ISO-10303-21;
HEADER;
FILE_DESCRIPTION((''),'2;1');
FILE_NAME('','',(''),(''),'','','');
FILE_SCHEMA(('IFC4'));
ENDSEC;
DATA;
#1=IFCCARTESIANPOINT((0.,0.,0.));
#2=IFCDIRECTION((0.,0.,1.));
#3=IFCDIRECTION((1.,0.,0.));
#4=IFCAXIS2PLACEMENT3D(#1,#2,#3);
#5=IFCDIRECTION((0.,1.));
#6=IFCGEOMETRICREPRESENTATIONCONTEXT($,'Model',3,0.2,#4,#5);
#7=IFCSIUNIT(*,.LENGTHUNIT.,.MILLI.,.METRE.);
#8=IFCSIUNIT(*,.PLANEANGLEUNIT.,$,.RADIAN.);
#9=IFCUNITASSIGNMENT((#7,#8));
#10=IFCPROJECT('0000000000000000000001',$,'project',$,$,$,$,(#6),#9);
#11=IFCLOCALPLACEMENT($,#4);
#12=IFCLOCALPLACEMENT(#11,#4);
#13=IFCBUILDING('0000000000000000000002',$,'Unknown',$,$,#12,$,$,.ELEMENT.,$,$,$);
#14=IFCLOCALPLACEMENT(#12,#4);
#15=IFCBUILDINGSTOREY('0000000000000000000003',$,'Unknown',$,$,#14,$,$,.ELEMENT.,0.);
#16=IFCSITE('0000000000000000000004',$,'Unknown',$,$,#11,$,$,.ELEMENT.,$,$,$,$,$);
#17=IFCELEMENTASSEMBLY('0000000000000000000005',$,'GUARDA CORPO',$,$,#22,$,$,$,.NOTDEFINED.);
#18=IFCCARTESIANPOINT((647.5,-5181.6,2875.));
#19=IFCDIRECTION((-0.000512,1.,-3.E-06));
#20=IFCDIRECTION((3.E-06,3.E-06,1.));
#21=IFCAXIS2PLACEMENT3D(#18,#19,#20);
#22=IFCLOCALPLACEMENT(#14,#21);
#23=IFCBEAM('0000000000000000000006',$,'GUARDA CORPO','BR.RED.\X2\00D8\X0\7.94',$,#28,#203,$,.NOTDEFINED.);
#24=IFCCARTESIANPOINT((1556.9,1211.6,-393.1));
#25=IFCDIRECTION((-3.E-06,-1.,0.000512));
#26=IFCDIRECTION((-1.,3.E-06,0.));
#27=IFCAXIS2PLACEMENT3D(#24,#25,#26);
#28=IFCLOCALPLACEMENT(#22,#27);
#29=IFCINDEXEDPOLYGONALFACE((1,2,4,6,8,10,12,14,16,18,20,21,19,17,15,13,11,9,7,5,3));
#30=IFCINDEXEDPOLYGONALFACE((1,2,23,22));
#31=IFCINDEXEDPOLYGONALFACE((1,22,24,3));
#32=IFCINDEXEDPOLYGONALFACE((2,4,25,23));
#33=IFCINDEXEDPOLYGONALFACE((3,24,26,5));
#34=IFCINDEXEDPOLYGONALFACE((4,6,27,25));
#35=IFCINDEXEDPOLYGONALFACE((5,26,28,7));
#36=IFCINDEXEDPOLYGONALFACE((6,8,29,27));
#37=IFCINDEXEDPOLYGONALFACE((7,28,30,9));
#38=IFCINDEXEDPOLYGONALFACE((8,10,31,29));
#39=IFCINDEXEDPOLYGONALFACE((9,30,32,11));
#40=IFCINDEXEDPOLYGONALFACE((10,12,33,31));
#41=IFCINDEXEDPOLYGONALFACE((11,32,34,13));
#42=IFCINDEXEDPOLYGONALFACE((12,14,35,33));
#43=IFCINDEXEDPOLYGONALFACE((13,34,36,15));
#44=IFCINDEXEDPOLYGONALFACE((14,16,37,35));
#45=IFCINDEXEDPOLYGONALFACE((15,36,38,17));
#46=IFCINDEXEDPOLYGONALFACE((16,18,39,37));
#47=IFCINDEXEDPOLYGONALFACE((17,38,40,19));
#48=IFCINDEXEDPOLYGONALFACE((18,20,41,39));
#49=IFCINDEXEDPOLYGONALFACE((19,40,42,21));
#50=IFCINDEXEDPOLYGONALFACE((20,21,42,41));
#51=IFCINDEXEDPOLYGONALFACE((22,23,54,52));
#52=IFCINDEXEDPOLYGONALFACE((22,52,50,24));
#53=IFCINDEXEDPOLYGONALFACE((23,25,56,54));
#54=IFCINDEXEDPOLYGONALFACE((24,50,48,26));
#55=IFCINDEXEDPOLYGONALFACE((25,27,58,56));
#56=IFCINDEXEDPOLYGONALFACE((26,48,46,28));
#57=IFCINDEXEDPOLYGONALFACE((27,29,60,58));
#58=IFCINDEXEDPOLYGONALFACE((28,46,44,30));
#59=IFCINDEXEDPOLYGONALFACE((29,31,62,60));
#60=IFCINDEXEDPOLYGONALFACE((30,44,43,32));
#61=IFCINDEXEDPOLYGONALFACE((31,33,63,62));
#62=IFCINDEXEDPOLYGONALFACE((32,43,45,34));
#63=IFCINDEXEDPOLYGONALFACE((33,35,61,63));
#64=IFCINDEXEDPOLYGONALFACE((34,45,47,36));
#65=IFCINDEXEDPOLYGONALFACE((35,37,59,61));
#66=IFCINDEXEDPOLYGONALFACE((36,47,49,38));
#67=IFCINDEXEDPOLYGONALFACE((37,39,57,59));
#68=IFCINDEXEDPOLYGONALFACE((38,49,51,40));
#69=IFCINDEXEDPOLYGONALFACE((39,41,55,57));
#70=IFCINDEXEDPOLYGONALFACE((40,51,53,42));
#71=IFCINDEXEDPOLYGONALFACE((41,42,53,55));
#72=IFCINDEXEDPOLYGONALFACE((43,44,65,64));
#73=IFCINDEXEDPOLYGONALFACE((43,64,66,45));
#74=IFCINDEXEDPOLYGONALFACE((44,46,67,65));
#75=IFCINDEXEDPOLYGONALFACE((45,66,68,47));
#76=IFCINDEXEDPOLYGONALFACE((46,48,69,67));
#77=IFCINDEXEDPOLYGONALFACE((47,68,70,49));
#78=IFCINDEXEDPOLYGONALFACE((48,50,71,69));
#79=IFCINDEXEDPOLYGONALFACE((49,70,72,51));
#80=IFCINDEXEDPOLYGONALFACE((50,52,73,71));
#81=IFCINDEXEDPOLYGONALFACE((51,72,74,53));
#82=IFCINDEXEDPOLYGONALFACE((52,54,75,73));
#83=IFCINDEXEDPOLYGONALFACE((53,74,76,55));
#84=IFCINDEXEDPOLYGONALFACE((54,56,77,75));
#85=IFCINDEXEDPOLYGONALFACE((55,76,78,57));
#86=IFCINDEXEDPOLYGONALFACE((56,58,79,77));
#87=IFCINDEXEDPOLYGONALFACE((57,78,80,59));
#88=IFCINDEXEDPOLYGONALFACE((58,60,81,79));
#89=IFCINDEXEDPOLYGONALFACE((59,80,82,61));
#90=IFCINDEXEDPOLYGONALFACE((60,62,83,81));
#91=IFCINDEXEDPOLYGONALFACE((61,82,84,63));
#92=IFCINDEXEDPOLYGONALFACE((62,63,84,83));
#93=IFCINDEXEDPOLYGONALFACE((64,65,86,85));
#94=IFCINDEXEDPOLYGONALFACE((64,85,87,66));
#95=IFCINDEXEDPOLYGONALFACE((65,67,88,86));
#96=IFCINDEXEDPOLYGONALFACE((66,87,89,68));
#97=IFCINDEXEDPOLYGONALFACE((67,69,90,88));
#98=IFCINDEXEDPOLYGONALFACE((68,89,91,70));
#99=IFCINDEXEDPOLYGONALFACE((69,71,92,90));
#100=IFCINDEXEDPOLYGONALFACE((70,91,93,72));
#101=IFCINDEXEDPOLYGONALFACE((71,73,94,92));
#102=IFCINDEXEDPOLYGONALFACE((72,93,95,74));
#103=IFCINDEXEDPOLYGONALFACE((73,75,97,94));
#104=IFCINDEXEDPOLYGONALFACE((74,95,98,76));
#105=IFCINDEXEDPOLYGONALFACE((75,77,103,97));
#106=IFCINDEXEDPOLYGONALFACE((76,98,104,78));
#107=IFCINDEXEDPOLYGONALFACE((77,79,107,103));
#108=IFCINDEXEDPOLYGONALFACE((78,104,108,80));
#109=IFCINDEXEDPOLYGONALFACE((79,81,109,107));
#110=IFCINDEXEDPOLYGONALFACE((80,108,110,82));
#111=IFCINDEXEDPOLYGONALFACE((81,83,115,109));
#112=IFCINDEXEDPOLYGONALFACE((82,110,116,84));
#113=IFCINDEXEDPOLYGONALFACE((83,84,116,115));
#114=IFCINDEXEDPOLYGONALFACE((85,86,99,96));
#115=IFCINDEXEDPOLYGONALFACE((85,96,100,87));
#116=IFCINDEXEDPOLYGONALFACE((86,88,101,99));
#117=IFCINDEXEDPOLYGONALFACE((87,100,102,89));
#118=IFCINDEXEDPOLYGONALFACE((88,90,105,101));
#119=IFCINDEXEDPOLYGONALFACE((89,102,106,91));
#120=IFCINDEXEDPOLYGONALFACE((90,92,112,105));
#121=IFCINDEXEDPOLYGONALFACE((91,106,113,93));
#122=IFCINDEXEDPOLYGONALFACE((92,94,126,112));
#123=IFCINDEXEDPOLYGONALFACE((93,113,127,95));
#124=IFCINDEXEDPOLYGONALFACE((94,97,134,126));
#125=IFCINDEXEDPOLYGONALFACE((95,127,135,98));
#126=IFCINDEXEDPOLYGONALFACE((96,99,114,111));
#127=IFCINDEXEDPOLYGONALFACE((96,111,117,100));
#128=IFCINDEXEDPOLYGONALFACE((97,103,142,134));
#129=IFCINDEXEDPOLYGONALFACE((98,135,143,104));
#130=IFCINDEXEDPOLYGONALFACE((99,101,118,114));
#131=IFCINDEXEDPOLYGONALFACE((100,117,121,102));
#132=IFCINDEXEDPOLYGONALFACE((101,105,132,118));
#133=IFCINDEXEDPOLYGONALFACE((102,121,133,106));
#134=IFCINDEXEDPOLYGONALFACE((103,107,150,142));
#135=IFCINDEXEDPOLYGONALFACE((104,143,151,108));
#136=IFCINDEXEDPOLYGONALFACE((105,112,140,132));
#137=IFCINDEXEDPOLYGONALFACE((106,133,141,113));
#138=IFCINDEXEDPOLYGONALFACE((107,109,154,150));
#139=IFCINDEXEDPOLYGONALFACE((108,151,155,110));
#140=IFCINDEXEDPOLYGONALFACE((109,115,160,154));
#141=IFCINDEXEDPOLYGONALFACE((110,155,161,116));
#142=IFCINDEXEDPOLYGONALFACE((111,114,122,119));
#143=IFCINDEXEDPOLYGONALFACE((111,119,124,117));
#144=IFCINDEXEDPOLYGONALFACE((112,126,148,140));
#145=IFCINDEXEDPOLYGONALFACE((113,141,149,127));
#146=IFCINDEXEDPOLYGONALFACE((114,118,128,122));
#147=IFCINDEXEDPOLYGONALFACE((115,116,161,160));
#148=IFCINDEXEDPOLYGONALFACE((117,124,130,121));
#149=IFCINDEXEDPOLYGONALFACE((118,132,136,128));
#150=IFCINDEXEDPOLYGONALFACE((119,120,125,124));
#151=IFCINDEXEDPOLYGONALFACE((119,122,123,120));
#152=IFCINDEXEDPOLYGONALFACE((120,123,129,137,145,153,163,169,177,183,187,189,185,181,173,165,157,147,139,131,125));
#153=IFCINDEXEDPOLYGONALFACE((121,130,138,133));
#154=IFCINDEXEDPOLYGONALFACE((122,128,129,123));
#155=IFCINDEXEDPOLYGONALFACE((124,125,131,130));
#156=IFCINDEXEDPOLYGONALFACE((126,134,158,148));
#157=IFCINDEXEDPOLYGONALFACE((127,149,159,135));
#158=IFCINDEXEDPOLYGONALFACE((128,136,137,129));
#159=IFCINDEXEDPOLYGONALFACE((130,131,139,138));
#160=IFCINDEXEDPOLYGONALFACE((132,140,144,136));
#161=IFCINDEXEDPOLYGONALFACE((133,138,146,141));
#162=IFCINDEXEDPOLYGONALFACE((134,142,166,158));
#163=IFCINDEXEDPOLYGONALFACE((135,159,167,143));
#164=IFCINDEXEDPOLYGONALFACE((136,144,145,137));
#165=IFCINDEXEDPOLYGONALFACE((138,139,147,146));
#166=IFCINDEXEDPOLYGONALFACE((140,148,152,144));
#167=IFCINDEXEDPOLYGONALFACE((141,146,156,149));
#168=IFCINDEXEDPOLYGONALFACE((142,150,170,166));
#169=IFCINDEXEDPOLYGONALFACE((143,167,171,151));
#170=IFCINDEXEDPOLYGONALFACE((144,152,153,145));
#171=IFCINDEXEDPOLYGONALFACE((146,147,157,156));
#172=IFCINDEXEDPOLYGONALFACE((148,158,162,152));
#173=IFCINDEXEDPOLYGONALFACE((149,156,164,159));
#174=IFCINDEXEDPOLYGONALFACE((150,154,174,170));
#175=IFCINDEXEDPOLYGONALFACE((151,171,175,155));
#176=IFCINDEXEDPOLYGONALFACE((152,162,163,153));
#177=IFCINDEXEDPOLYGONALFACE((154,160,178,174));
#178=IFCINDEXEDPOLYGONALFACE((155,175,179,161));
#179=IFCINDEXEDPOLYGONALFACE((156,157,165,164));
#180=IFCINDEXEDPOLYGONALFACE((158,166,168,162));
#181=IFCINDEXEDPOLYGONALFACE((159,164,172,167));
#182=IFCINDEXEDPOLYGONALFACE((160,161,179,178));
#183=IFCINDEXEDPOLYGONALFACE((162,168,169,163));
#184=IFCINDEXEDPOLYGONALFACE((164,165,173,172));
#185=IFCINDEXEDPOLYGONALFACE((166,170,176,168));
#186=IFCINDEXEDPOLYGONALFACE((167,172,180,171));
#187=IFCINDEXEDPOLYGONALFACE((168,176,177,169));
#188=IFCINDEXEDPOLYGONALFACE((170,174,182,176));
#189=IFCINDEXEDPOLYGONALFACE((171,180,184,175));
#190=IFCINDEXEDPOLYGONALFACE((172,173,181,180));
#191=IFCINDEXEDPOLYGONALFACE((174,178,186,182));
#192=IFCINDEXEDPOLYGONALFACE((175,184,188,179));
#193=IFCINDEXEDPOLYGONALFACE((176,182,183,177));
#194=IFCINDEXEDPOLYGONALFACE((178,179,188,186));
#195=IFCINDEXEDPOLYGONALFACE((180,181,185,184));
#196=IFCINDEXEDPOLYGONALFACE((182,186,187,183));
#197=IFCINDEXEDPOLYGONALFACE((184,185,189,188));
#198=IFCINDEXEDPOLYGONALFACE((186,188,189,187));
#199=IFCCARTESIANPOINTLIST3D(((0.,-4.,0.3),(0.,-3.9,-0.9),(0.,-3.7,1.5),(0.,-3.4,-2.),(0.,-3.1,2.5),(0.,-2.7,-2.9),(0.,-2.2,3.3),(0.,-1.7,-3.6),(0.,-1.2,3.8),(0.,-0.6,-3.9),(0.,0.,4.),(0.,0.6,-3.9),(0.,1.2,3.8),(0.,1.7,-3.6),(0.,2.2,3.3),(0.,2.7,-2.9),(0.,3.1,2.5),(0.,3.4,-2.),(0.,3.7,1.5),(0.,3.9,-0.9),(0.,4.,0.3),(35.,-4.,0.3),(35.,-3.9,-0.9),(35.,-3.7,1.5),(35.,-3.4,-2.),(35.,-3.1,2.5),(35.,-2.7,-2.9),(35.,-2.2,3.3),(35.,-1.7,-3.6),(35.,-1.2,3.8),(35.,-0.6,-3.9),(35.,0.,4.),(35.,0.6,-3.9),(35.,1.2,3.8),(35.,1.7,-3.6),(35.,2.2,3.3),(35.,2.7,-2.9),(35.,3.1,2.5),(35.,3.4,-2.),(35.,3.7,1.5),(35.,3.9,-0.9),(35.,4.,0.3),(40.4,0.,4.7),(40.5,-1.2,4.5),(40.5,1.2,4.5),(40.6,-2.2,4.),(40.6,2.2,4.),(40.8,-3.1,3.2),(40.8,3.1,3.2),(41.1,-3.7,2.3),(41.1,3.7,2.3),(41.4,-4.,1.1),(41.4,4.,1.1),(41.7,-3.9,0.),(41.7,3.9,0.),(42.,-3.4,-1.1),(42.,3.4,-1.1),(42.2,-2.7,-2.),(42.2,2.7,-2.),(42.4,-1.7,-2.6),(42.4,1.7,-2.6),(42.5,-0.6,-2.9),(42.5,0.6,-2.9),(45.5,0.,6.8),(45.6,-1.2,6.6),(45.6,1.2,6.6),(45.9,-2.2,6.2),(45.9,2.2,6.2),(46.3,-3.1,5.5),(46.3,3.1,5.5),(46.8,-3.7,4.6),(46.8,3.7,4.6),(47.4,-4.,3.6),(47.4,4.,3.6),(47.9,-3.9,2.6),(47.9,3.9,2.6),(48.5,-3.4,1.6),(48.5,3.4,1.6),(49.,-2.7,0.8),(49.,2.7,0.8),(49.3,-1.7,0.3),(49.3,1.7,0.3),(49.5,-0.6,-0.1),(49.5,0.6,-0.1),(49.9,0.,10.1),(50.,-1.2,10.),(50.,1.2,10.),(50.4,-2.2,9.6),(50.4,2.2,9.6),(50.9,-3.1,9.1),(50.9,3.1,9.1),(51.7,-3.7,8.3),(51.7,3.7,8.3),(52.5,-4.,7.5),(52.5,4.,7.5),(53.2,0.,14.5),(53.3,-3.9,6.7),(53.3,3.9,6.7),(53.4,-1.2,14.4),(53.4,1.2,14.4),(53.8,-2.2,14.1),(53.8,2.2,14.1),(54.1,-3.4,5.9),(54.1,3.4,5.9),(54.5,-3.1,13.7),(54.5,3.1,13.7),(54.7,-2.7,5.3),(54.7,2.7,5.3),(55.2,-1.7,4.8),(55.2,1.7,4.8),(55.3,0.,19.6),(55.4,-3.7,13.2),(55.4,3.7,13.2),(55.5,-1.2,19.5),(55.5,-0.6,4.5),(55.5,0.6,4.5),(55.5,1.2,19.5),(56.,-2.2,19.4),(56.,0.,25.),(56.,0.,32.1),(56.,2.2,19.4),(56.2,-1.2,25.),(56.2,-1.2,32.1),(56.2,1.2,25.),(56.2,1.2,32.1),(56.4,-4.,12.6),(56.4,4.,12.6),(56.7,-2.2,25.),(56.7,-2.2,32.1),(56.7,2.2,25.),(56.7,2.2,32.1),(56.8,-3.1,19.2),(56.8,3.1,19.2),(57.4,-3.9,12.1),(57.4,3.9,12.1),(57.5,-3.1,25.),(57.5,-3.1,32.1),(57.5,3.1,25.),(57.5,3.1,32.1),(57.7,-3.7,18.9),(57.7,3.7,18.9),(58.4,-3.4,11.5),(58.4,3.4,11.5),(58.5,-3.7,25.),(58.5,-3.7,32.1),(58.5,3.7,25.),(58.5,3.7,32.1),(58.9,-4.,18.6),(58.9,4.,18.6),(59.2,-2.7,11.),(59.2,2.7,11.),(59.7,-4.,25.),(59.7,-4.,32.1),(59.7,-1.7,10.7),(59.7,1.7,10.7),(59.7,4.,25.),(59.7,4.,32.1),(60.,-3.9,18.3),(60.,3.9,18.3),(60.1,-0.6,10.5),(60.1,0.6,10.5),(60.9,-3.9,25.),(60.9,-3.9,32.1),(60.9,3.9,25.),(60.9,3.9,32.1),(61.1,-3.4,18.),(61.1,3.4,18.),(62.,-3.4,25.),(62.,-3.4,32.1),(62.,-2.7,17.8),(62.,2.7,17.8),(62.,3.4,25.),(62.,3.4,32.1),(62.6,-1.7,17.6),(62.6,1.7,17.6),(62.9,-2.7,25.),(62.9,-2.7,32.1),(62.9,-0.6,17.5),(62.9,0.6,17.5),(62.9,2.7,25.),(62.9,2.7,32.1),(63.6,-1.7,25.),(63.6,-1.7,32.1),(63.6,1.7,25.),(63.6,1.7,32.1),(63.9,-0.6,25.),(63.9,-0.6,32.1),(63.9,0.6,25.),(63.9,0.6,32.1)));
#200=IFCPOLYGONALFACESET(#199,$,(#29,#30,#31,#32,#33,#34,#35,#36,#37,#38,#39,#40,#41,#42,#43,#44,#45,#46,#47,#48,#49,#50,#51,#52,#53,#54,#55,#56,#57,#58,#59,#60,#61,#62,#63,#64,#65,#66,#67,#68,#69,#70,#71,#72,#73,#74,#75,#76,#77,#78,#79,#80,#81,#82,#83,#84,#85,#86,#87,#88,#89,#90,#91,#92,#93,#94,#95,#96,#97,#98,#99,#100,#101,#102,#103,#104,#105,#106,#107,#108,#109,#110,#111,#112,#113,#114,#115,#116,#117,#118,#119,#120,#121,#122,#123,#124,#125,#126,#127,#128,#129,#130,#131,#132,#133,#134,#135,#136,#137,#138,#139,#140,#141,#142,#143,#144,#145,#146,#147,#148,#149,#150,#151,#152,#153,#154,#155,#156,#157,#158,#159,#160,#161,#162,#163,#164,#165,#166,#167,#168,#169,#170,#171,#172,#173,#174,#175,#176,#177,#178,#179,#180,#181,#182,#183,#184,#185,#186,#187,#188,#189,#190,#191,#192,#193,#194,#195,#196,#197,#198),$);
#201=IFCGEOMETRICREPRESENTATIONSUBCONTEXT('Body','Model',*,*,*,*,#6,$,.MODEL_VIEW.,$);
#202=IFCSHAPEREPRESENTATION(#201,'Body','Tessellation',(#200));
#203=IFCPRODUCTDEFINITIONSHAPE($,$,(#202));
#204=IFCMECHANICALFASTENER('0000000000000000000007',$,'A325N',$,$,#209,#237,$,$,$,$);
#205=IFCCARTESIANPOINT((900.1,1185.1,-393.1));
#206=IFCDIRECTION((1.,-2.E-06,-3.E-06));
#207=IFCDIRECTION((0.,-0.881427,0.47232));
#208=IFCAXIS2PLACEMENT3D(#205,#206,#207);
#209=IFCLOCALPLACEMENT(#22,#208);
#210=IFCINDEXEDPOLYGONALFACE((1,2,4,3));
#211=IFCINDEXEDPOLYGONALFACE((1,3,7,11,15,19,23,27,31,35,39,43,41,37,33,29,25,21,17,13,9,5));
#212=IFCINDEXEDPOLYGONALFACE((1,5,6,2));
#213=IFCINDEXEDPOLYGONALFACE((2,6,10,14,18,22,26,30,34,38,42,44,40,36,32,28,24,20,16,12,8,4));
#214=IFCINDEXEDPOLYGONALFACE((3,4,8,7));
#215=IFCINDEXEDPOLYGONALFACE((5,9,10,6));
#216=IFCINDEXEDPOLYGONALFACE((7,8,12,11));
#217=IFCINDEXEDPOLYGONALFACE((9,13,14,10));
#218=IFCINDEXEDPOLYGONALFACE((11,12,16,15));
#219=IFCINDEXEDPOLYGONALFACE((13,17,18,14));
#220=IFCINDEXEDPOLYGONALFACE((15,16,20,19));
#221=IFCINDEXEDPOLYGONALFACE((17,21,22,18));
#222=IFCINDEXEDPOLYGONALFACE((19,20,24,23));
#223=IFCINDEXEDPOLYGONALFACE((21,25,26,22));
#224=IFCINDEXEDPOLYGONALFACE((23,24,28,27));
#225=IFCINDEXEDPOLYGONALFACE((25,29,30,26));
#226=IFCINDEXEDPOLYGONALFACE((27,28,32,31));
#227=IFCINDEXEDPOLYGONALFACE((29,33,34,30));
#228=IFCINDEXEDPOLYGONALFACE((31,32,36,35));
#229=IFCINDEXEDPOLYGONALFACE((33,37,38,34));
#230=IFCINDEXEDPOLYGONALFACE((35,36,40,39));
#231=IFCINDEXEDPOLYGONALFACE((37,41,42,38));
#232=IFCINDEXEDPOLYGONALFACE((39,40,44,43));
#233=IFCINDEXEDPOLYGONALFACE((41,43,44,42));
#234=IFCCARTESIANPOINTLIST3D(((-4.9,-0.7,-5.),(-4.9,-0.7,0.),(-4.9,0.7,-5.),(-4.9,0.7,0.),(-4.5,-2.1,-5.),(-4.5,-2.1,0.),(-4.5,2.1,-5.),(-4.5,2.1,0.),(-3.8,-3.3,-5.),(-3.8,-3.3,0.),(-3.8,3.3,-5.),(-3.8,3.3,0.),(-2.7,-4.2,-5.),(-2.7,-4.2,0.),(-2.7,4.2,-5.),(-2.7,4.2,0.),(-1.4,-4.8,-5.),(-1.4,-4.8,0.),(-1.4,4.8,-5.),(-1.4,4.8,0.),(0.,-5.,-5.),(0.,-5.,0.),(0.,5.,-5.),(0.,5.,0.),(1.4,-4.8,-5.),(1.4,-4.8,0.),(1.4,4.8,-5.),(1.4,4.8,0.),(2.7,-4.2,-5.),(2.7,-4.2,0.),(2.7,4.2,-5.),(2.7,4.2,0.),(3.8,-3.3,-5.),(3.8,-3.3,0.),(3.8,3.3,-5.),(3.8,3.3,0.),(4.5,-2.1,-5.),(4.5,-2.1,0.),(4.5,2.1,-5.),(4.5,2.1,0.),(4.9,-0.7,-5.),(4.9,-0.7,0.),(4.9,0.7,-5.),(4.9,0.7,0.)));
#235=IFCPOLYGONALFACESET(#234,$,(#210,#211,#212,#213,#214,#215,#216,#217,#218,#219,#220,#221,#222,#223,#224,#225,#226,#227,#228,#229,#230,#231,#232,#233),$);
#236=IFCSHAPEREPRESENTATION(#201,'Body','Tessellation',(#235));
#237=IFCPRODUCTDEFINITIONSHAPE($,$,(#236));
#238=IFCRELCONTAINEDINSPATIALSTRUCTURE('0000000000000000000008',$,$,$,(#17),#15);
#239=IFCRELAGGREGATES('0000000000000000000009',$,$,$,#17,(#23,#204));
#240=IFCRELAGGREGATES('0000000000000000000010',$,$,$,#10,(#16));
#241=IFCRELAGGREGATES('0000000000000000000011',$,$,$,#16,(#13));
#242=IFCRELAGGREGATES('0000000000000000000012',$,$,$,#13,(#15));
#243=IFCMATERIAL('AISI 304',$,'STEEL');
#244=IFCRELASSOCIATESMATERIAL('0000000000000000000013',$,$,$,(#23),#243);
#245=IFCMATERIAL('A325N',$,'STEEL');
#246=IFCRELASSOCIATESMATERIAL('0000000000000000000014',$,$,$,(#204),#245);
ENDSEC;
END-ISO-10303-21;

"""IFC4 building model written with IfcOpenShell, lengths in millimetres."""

from ifc_helpers import new_model, entity, si_unit, direction, frame, origin_with_axes, place, context, subcontext, project, spatial, arc, indexed_curve, outline, extrude, source, transform, mapped, material, element, aggregate, save


model = new_model("IFC4")

# Units and contexts
model_context = context("Model", 3, precision=0.2, world=origin_with_axes(), true_north=direction((0.0, 1.0)))
body_context = subcontext(model_context, "Body", "Model", "MODEL_VIEW")
ifc_project = project(units=[si_unit("LENGTHUNIT", "METRE", prefix="MILLI"), si_unit("PLANEANGLEUNIT", "RADIAN")], contexts=[model_context])

# Site, building, storey
site_placement = place(None, origin_with_axes())
site = spatial("IfcSite", under=ifc_project, at=site_placement, Name="Unknown", CompositionType="ELEMENT")
building_placement = place(site_placement, origin_with_axes())
building = spatial("IfcBuilding", under=site, at=building_placement, Name="Unknown", CompositionType="ELEMENT")
storey_placement = place(building_placement, origin_with_axes())
storey = spatial("IfcBuildingStorey", under=building, at=storey_placement, Name="Unknown", CompositionType="ELEMENT", Elevation=0.0)

# Element assembly, beam
assembly_1_placement = place(storey_placement, frame((647.5, -5181.6, 2875.0), z_axis=(-0.000512, 1.0, -0.000003), x_axis=(0.000003, 0.000003, 1.0)))
assembly_1 = element("IfcElementAssembly", 1, at=assembly_1_placement, inside=storey, Name="GUARDA CORPO", PredefinedType="NOTDEFINED")
ifc_material_1 = material(Name="AISI 304", Category="STEEL")
beam_1_placement = place(assembly_1_placement, frame((1556.9, 1211.6, -393.1), z_axis=(-0.000003, -1.0, 0.000512), x_axis=(-1.0, 0.000003, 0.0)))
beam_1 = element("IfcBeam", 2, at=beam_1_placement, material=ifc_material_1, Name="GUARDA CORPO", Description="BR.RED.Ø7.94", PredefinedType="NOTDEFINED", context=body_context, shape_type="SolidModel", body=[
    entity("IfcSweptDiskSolid", entity("IfcIndexedPolyCurve", entity("IfcCartesianPointList3D", [[0.0, 0.0, 0.0], [35.0, 0.0, 0.0], [52.7, 0.0, 7.3], [60.0, 0.0, 25.0], [60.0, 0.0, 32.1]]), [entity("IfcLineIndex", [1, 2]), entity("IfcArcIndex", [2, 3, 4]), entity("IfcLineIndex", [4, 5])]), 4.0),
])

# Mechanical fastener
ifc_material_2 = material(Name="A325N", Category="STEEL")
shared_shape_1 = source(origin_with_axes(), body_context, "Body", "SweptSolid", [
    extrude(outline(indexed_curve([(5.0, 0.0), (0.0, 5.0), (-5.0, 0.0), (0.0, -5.0)], segments=[arc(1, 2, 3), arc(3, 4, 1)])), frame((0.0, 0.0, 0.0), z_axis=(0.0, 0.0, -1.0), x_axis=(0.0, 1.0, 0.0)), (0.0, 0.0, 1.0), 5.0),
])
mechanical_fastener_1_placement = place(assembly_1_placement, frame((900.1, 1185.1, -393.1), z_axis=(1.0, -0.000002, -0.000003), x_axis=(0.0, -0.881427, 0.47232)))
mechanical_fastener_1 = element("IfcMechanicalFastener", 3, at=mechanical_fastener_1_placement, material=ifc_material_2, Name="A325N", context=body_context, shape_type="MappedRepresentation", body=[
    mapped(shared_shape_1, transform((0.0, 0.0, 0.0))),
])
aggregate(assembly_1, [beam_1, mechanical_fastener_1])

save(model, "model.ifc")
